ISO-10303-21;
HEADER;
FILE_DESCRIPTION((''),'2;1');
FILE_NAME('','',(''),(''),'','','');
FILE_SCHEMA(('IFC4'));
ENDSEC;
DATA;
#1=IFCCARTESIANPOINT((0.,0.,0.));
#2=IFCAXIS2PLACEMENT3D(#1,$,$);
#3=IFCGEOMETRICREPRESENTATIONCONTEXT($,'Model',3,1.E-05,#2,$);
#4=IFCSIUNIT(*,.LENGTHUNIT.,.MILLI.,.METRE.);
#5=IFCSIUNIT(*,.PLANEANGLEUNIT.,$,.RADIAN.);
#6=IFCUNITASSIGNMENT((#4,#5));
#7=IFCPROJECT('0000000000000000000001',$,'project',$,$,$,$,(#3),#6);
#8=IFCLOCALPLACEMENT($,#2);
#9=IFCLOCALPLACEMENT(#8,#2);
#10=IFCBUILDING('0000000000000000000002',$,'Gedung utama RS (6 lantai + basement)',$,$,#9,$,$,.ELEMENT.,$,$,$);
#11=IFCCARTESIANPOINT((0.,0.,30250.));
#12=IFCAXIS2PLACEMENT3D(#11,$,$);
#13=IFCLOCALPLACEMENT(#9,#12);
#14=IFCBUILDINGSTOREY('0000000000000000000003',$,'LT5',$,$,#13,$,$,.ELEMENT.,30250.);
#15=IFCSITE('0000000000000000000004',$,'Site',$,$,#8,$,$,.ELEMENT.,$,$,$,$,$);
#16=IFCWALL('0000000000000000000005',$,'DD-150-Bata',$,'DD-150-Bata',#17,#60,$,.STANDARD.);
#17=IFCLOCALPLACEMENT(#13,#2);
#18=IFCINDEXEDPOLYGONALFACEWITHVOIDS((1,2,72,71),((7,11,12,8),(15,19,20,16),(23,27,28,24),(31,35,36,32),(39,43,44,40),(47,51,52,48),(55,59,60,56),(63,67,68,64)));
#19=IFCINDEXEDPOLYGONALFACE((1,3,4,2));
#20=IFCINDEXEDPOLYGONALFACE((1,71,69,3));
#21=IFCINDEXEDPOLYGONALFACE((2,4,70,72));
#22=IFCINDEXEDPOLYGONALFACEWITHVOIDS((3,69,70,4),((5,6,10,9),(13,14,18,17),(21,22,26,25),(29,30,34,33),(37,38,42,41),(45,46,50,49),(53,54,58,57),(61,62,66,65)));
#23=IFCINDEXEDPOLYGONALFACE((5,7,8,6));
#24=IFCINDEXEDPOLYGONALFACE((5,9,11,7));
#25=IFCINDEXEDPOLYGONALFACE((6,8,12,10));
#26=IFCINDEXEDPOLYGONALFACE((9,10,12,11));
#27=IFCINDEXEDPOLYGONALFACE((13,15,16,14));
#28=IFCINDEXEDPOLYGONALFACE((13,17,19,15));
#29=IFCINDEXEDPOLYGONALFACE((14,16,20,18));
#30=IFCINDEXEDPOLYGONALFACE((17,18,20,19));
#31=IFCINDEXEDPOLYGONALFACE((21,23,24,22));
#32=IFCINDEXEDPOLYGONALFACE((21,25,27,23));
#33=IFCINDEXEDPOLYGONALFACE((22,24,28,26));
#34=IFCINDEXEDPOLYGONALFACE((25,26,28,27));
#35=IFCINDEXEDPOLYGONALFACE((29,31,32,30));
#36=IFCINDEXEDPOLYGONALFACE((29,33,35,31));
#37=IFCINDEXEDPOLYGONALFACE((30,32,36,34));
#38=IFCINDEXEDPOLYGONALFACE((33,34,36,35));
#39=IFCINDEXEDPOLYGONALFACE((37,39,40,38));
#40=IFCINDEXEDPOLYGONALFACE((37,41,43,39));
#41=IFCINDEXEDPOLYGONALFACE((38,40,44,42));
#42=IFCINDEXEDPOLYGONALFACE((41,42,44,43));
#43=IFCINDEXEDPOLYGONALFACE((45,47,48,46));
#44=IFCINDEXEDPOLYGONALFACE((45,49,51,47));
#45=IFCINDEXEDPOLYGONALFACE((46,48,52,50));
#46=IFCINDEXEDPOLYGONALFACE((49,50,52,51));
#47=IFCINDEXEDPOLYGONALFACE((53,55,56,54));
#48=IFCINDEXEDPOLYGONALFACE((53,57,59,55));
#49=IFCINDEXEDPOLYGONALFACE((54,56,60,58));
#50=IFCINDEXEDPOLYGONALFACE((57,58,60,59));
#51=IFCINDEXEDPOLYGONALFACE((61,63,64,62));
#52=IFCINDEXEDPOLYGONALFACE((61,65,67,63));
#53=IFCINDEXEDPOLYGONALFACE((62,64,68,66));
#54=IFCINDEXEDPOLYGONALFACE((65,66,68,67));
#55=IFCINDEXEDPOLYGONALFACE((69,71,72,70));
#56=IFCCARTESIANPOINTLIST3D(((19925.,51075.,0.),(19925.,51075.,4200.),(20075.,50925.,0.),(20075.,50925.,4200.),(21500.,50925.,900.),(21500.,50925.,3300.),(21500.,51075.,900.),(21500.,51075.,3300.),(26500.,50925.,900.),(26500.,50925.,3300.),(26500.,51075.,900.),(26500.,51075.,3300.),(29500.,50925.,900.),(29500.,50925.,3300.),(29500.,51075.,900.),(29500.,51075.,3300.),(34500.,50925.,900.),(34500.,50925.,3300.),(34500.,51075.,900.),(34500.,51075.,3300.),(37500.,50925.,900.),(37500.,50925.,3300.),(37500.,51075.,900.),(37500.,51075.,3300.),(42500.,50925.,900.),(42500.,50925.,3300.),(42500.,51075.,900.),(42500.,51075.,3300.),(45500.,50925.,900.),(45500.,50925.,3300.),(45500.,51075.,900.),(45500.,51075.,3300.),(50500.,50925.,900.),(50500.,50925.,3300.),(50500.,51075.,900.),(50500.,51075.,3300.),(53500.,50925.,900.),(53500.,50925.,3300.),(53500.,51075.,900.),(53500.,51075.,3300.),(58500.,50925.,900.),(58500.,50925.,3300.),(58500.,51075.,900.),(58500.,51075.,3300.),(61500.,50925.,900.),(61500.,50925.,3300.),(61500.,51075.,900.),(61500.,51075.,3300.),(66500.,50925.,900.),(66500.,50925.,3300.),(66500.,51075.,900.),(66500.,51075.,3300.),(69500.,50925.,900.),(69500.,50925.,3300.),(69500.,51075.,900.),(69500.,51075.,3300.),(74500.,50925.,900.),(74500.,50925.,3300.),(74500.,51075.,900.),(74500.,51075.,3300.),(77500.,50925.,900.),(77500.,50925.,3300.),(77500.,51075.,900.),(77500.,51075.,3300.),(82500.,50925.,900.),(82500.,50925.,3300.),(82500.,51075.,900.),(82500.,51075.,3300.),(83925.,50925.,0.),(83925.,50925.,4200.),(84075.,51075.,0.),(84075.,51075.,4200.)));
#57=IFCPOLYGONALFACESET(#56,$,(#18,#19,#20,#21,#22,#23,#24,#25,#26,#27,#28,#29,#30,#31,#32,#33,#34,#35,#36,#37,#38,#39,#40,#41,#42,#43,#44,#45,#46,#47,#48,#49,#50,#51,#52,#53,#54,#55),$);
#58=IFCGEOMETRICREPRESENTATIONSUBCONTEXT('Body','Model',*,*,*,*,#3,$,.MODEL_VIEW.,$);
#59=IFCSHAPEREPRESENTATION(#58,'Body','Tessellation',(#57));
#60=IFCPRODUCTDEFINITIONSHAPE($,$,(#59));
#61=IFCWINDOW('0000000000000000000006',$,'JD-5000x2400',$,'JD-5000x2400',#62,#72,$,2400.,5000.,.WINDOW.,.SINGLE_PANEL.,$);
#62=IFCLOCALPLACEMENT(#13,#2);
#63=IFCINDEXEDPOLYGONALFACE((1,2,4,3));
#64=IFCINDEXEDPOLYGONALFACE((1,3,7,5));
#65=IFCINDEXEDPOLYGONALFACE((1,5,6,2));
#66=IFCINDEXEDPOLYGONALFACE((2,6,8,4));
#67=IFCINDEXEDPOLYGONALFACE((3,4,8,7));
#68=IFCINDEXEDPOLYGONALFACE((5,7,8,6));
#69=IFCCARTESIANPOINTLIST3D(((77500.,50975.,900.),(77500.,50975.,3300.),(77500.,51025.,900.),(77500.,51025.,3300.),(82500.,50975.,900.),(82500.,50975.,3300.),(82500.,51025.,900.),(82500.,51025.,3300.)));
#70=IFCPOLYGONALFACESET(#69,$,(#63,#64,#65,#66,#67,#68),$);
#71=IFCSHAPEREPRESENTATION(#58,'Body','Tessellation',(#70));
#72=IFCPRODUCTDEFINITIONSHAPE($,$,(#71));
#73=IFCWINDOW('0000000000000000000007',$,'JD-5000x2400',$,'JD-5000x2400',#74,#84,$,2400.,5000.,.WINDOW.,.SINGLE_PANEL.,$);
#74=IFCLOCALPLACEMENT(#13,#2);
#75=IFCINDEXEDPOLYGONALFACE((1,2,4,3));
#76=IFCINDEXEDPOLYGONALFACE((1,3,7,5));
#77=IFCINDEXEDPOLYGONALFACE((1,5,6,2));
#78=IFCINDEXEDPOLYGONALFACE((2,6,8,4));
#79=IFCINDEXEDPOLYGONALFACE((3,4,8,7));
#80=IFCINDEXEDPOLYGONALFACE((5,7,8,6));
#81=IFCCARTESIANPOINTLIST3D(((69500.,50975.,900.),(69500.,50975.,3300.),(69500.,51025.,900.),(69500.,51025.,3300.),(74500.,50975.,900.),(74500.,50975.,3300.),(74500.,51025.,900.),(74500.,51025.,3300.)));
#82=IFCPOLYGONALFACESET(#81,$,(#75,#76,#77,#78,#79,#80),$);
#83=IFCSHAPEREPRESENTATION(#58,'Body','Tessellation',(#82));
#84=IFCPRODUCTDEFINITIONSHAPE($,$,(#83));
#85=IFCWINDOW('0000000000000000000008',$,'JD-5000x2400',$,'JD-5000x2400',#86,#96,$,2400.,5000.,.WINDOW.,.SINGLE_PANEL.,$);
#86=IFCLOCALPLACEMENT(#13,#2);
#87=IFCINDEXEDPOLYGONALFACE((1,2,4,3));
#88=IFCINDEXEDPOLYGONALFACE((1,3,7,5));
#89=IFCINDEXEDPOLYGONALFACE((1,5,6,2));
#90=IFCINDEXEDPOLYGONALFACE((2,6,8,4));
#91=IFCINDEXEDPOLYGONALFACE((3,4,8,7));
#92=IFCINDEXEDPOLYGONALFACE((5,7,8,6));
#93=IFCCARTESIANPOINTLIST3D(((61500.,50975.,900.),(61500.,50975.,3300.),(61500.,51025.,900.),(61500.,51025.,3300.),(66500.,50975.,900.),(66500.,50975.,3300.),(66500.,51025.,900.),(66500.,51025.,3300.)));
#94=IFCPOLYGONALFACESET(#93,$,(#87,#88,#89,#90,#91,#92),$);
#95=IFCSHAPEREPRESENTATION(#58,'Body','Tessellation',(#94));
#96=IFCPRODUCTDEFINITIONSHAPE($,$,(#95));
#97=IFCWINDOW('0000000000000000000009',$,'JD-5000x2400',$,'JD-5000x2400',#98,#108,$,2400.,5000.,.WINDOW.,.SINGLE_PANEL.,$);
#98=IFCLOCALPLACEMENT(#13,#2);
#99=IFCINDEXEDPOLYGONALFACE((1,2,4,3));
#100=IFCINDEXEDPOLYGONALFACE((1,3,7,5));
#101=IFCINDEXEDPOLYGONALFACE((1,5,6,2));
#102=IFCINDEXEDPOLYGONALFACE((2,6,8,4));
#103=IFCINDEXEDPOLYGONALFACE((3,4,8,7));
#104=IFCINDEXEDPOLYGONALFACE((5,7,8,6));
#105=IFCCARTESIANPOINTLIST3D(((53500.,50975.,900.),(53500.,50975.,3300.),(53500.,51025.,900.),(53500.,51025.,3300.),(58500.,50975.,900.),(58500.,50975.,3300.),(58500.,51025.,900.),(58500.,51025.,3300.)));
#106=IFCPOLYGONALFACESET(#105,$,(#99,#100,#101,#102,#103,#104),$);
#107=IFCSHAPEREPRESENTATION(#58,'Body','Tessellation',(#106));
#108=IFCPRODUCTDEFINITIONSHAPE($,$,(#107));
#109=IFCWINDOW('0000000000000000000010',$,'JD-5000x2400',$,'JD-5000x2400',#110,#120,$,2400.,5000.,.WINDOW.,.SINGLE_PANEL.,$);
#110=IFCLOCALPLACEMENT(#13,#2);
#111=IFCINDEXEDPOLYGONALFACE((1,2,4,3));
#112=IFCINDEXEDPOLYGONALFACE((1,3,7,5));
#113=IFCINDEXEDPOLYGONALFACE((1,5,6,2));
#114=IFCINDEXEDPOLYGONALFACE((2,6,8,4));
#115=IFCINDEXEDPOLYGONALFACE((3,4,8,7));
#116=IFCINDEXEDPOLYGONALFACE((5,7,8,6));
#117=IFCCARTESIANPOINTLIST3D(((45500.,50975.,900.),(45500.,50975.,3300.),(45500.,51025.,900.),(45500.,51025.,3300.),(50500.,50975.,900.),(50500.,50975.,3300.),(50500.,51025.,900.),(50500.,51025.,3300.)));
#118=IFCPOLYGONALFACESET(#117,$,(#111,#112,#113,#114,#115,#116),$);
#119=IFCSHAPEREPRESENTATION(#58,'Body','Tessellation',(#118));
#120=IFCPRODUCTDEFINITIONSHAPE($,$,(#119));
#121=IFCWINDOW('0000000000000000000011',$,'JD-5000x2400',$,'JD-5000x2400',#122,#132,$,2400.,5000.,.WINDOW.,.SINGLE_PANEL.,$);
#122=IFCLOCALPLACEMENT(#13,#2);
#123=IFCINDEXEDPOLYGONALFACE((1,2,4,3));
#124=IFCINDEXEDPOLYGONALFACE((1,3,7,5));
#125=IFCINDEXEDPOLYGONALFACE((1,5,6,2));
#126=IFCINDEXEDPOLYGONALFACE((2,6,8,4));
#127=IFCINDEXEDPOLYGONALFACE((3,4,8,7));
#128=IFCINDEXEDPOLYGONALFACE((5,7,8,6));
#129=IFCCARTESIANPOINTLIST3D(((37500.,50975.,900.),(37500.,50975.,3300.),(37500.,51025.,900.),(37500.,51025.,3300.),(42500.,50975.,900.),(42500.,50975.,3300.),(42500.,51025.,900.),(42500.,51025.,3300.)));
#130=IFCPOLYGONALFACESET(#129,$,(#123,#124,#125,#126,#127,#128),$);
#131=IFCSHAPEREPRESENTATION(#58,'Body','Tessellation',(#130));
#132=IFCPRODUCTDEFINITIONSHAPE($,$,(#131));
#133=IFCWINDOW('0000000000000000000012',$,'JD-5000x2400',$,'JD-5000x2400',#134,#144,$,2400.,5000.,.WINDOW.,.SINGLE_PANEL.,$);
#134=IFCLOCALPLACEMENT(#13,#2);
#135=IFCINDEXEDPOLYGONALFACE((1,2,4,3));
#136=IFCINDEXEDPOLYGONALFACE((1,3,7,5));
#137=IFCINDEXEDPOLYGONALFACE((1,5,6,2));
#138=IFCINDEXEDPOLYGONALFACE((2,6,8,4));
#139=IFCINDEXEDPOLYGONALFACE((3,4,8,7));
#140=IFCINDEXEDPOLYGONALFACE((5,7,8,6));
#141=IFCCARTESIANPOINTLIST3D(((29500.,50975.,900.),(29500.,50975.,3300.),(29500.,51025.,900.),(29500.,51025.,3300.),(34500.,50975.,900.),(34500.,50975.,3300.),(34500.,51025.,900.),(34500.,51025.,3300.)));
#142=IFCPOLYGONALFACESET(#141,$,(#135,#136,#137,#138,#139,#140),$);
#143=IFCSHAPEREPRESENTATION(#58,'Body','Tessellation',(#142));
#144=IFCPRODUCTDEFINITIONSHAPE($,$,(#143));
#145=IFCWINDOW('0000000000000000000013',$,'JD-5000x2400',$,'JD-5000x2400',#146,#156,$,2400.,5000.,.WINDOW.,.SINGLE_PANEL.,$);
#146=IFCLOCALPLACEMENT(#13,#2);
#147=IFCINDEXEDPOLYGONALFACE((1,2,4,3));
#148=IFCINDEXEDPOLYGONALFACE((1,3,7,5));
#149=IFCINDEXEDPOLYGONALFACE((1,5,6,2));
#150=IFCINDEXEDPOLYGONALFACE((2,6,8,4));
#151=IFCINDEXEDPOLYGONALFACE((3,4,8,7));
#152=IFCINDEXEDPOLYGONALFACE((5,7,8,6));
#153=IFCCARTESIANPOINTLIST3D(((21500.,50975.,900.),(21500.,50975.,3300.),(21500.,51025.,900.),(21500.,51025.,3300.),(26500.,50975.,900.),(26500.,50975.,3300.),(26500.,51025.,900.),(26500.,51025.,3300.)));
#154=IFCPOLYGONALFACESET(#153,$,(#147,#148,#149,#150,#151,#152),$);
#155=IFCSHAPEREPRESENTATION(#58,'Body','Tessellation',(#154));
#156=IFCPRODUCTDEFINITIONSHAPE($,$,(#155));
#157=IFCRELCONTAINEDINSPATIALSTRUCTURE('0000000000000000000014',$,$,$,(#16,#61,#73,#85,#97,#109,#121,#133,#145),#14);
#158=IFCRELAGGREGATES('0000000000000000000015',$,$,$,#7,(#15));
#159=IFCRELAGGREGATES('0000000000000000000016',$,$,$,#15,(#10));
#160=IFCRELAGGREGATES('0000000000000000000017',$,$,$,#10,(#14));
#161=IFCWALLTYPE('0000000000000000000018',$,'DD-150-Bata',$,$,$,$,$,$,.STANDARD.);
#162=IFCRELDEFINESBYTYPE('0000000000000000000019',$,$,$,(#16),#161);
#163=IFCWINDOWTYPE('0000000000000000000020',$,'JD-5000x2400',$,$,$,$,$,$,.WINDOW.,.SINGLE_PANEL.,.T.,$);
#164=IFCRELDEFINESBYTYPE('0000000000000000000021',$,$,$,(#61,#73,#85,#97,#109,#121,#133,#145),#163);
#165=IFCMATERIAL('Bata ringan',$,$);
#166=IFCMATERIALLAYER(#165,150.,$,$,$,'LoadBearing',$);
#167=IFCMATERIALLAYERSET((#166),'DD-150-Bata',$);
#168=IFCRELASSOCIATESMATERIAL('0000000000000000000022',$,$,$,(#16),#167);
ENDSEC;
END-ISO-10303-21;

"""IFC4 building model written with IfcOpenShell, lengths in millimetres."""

from ifc_helpers import new_model, si_unit, frame, frame_2d, origin, place, context, subcontext, project, spatial, polyline, rectangle, outline, extrude, material, layer, layer_set, layer_usage, type_object, element, fill, save


model = new_model("IFC4")

# Units and contexts
model_context = context("Model", 3, precision=1e-05, world=origin())
body_context = subcontext(model_context, "Body", "Model", "MODEL_VIEW")
ifc_project = project(units=[si_unit("LENGTHUNIT", "METRE", prefix="MILLI"), si_unit("PLANEANGLEUNIT", "RADIAN")], contexts=[model_context])

# Site, building, storey
site_placement = place(None, origin())
site = spatial("IfcSite", under=ifc_project, at=site_placement, Name="Site", CompositionType="ELEMENT")
building_placement = place(site_placement, origin())
building = spatial("IfcBuilding", under=site, at=building_placement, Name="Gedung utama RS (6 lantai + basement)", CompositionType="ELEMENT")
storey_placement = place(building_placement, frame((0.0, 0.0, 30250.0)))
storey = spatial("IfcBuildingStorey", under=building, at=storey_placement, Name="LT5", CompositionType="ELEMENT", Elevation=30250.0)

# Wall, openings, windows
ifc_material_1 = material(Name="Bata ringan")
ifc_layer = layer(ifc_material_1, 150.0, Category="LoadBearing")
ifc_layer_set = layer_set([ifc_layer], Name="DD-150-Bata")
ifc_layer_usage = layer_usage(ifc_layer_set, "AXIS2", "NEGATIVE", 75.0)
wall_type = type_object("IfcWallType", Name="DD-150-Bata", PredefinedType="STANDARD")
window_type = type_object("IfcWindowType", Name="JD-5000x2400", ParameterTakesPrecedence=True, PartitioningType="SINGLE_PANEL", PredefinedType="WINDOW")
wall_1_placement = place(storey_placement, frame((84000.0, 51000.0, 0.0), z_axis=(0.0, 0.0, 1.0), x_axis=(-1.0, 0.0, 0.0)))
wall_1 = element("IfcWall", 1, at=wall_1_placement, inside=storey, type_object=wall_type, material=ifc_layer_usage, Name="DD-150-Bata", ObjectType="DD-150-Bata", PredefinedType="STANDARD", context=body_context, shape_type="SweptSolid", body=[
    extrude(outline(polyline([(-75.0, -75.0), (0.0, 0.0), (75.0, 75.0), (63925.0, 75.0), (64000.0, 0.0), (64075.0, -75.0), (-75.0, -75.0)])), origin(), (0.0, 0.0, 1.0), 4200.0),
])
opening_1_placement = place(wall_1_placement, frame((1500.0, 0.0, 900.0), z_axis=(0.0, 0.0, 1.0), x_axis=(1.0, 0.0, 0.0)))
opening_1 = element("IfcOpeningElement", 2, at=opening_1_placement, cuts=wall_1, PredefinedType="OPENING", context=body_context, shape_type="SweptSolid", body=[
    extrude(rectangle(XDim=5000.0, YDim=170.0, at=frame_2d((2500.0, 0.0))), origin(), (0.0, 0.0, 1.0), 2400.0),
])
opening_2_placement = place(wall_1_placement, frame((9500.0, 0.0, 900.0), z_axis=(0.0, 0.0, 1.0), x_axis=(1.0, 0.0, 0.0)))
opening_2 = element("IfcOpeningElement", 3, at=opening_2_placement, cuts=wall_1, PredefinedType="OPENING", context=body_context, shape_type="SweptSolid", body=[
    extrude(rectangle(XDim=5000.0, YDim=170.0, at=frame_2d((2500.0, 0.0))), origin(), (0.0, 0.0, 1.0), 2400.0),
])
opening_3_placement = place(wall_1_placement, frame((17500.0, 0.0, 900.0), z_axis=(0.0, 0.0, 1.0), x_axis=(1.0, 0.0, 0.0)))
opening_3 = element("IfcOpeningElement", 4, at=opening_3_placement, cuts=wall_1, PredefinedType="OPENING", context=body_context, shape_type="SweptSolid", body=[
    extrude(rectangle(XDim=5000.0, YDim=170.0, at=frame_2d((2500.0, 0.0))), origin(), (0.0, 0.0, 1.0), 2400.0),
])
opening_4_placement = place(wall_1_placement, frame((25500.0, 0.0, 900.0), z_axis=(0.0, 0.0, 1.0), x_axis=(1.0, 0.0, 0.0)))
opening_4 = element("IfcOpeningElement", 5, at=opening_4_placement, cuts=wall_1, PredefinedType="OPENING", context=body_context, shape_type="SweptSolid", body=[
    extrude(rectangle(XDim=5000.0, YDim=170.0, at=frame_2d((2500.0, 0.0))), origin(), (0.0, 0.0, 1.0), 2400.0),
])
opening_5_placement = place(wall_1_placement, frame((33500.0, 0.0, 900.0), z_axis=(0.0, 0.0, 1.0), x_axis=(1.0, 0.0, 0.0)))
opening_5 = element("IfcOpeningElement", 6, at=opening_5_placement, cuts=wall_1, PredefinedType="OPENING", context=body_context, shape_type="SweptSolid", body=[
    extrude(rectangle(XDim=5000.0, YDim=170.0, at=frame_2d((2500.0, 0.0))), origin(), (0.0, 0.0, 1.0), 2400.0),
])
opening_6_placement = place(wall_1_placement, frame((41500.0, 0.0, 900.0), z_axis=(0.0, 0.0, 1.0), x_axis=(1.0, 0.0, 0.0)))
opening_6 = element("IfcOpeningElement", 7, at=opening_6_placement, cuts=wall_1, PredefinedType="OPENING", context=body_context, shape_type="SweptSolid", body=[
    extrude(rectangle(XDim=5000.0, YDim=170.0, at=frame_2d((2500.0, 0.0))), origin(), (0.0, 0.0, 1.0), 2400.0),
])
opening_7_placement = place(wall_1_placement, frame((49500.0, 0.0, 900.0), z_axis=(0.0, 0.0, 1.0), x_axis=(1.0, 0.0, 0.0)))
opening_7 = element("IfcOpeningElement", 8, at=opening_7_placement, cuts=wall_1, PredefinedType="OPENING", context=body_context, shape_type="SweptSolid", body=[
    extrude(rectangle(XDim=5000.0, YDim=170.0, at=frame_2d((2500.0, 0.0))), origin(), (0.0, 0.0, 1.0), 2400.0),
])
opening_8_placement = place(wall_1_placement, frame((57500.0, 0.0, 900.0), z_axis=(0.0, 0.0, 1.0), x_axis=(1.0, 0.0, 0.0)))
opening_8 = element("IfcOpeningElement", 9, at=opening_8_placement, cuts=wall_1, PredefinedType="OPENING", context=body_context, shape_type="SweptSolid", body=[
    extrude(rectangle(XDim=5000.0, YDim=170.0, at=frame_2d((2500.0, 0.0))), origin(), (0.0, 0.0, 1.0), 2400.0),
])
window_1_placement = place(opening_1_placement, origin())
window_1 = element("IfcWindow", 10, at=window_1_placement, inside=storey, type_object=window_type, Name="JD-5000x2400", ObjectType="JD-5000x2400", OverallHeight=2400.0, OverallWidth=5000.0, PartitioningType="SINGLE_PANEL", PredefinedType="WINDOW", context=body_context, shape_type="SweptSolid", body=[
    extrude(rectangle(XDim=5000.0, YDim=50.0, at=frame_2d((2500.0, 0.0))), origin(), (0.0, 0.0, 1.0), 2400.0),
])
fill(opening_1, window_1)
window_2_placement = place(opening_2_placement, origin())
window_2 = element("IfcWindow", 11, at=window_2_placement, inside=storey, type_object=window_type, Name="JD-5000x2400", ObjectType="JD-5000x2400", OverallHeight=2400.0, OverallWidth=5000.0, PartitioningType="SINGLE_PANEL", PredefinedType="WINDOW", context=body_context, shape_type="SweptSolid", body=[
    extrude(rectangle(XDim=5000.0, YDim=50.0, at=frame_2d((2500.0, 0.0))), origin(), (0.0, 0.0, 1.0), 2400.0),
])
fill(opening_2, window_2)
window_3_placement = place(opening_3_placement, origin())
window_3 = element("IfcWindow", 12, at=window_3_placement, inside=storey, type_object=window_type, Name="JD-5000x2400", ObjectType="JD-5000x2400", OverallHeight=2400.0, OverallWidth=5000.0, PartitioningType="SINGLE_PANEL", PredefinedType="WINDOW", context=body_context, shape_type="SweptSolid", body=[
    extrude(rectangle(XDim=5000.0, YDim=50.0, at=frame_2d((2500.0, 0.0))), origin(), (0.0, 0.0, 1.0), 2400.0),
])
fill(opening_3, window_3)
window_4_placement = place(opening_4_placement, origin())
window_4 = element("IfcWindow", 13, at=window_4_placement, inside=storey, type_object=window_type, Name="JD-5000x2400", ObjectType="JD-5000x2400", OverallHeight=2400.0, OverallWidth=5000.0, PartitioningType="SINGLE_PANEL", PredefinedType="WINDOW", context=body_context, shape_type="SweptSolid", body=[
    extrude(rectangle(XDim=5000.0, YDim=50.0, at=frame_2d((2500.0, 0.0))), origin(), (0.0, 0.0, 1.0), 2400.0),
])
fill(opening_4, window_4)
window_5_placement = place(opening_5_placement, origin())
window_5 = element("IfcWindow", 14, at=window_5_placement, inside=storey, type_object=window_type, Name="JD-5000x2400", ObjectType="JD-5000x2400", OverallHeight=2400.0, OverallWidth=5000.0, PartitioningType="SINGLE_PANEL", PredefinedType="WINDOW", context=body_context, shape_type="SweptSolid", body=[
    extrude(rectangle(XDim=5000.0, YDim=50.0, at=frame_2d((2500.0, 0.0))), origin(), (0.0, 0.0, 1.0), 2400.0),
])
fill(opening_5, window_5)
window_6_placement = place(opening_6_placement, origin())
window_6 = element("IfcWindow", 15, at=window_6_placement, inside=storey, type_object=window_type, Name="JD-5000x2400", ObjectType="JD-5000x2400", OverallHeight=2400.0, OverallWidth=5000.0, PartitioningType="SINGLE_PANEL", PredefinedType="WINDOW", context=body_context, shape_type="SweptSolid", body=[
    extrude(rectangle(XDim=5000.0, YDim=50.0, at=frame_2d((2500.0, 0.0))), origin(), (0.0, 0.0, 1.0), 2400.0),
])
fill(opening_6, window_6)
window_7_placement = place(opening_7_placement, origin())
window_7 = element("IfcWindow", 16, at=window_7_placement, inside=storey, type_object=window_type, Name="JD-5000x2400", ObjectType="JD-5000x2400", OverallHeight=2400.0, OverallWidth=5000.0, PartitioningType="SINGLE_PANEL", PredefinedType="WINDOW", context=body_context, shape_type="SweptSolid", body=[
    extrude(rectangle(XDim=5000.0, YDim=50.0, at=frame_2d((2500.0, 0.0))), origin(), (0.0, 0.0, 1.0), 2400.0),
])
fill(opening_7, window_7)
window_8_placement = place(opening_8_placement, origin())
window_8 = element("IfcWindow", 17, at=window_8_placement, inside=storey, type_object=window_type, Name="JD-5000x2400", ObjectType="JD-5000x2400", OverallHeight=2400.0, OverallWidth=5000.0, PartitioningType="SINGLE_PANEL", PredefinedType="WINDOW", context=body_context, shape_type="SweptSolid", body=[
    extrude(rectangle(XDim=5000.0, YDim=50.0, at=frame_2d((2500.0, 0.0))), origin(), (0.0, 0.0, 1.0), 2400.0),
])
fill(opening_8, window_8)

save(model, "model.ifc")
